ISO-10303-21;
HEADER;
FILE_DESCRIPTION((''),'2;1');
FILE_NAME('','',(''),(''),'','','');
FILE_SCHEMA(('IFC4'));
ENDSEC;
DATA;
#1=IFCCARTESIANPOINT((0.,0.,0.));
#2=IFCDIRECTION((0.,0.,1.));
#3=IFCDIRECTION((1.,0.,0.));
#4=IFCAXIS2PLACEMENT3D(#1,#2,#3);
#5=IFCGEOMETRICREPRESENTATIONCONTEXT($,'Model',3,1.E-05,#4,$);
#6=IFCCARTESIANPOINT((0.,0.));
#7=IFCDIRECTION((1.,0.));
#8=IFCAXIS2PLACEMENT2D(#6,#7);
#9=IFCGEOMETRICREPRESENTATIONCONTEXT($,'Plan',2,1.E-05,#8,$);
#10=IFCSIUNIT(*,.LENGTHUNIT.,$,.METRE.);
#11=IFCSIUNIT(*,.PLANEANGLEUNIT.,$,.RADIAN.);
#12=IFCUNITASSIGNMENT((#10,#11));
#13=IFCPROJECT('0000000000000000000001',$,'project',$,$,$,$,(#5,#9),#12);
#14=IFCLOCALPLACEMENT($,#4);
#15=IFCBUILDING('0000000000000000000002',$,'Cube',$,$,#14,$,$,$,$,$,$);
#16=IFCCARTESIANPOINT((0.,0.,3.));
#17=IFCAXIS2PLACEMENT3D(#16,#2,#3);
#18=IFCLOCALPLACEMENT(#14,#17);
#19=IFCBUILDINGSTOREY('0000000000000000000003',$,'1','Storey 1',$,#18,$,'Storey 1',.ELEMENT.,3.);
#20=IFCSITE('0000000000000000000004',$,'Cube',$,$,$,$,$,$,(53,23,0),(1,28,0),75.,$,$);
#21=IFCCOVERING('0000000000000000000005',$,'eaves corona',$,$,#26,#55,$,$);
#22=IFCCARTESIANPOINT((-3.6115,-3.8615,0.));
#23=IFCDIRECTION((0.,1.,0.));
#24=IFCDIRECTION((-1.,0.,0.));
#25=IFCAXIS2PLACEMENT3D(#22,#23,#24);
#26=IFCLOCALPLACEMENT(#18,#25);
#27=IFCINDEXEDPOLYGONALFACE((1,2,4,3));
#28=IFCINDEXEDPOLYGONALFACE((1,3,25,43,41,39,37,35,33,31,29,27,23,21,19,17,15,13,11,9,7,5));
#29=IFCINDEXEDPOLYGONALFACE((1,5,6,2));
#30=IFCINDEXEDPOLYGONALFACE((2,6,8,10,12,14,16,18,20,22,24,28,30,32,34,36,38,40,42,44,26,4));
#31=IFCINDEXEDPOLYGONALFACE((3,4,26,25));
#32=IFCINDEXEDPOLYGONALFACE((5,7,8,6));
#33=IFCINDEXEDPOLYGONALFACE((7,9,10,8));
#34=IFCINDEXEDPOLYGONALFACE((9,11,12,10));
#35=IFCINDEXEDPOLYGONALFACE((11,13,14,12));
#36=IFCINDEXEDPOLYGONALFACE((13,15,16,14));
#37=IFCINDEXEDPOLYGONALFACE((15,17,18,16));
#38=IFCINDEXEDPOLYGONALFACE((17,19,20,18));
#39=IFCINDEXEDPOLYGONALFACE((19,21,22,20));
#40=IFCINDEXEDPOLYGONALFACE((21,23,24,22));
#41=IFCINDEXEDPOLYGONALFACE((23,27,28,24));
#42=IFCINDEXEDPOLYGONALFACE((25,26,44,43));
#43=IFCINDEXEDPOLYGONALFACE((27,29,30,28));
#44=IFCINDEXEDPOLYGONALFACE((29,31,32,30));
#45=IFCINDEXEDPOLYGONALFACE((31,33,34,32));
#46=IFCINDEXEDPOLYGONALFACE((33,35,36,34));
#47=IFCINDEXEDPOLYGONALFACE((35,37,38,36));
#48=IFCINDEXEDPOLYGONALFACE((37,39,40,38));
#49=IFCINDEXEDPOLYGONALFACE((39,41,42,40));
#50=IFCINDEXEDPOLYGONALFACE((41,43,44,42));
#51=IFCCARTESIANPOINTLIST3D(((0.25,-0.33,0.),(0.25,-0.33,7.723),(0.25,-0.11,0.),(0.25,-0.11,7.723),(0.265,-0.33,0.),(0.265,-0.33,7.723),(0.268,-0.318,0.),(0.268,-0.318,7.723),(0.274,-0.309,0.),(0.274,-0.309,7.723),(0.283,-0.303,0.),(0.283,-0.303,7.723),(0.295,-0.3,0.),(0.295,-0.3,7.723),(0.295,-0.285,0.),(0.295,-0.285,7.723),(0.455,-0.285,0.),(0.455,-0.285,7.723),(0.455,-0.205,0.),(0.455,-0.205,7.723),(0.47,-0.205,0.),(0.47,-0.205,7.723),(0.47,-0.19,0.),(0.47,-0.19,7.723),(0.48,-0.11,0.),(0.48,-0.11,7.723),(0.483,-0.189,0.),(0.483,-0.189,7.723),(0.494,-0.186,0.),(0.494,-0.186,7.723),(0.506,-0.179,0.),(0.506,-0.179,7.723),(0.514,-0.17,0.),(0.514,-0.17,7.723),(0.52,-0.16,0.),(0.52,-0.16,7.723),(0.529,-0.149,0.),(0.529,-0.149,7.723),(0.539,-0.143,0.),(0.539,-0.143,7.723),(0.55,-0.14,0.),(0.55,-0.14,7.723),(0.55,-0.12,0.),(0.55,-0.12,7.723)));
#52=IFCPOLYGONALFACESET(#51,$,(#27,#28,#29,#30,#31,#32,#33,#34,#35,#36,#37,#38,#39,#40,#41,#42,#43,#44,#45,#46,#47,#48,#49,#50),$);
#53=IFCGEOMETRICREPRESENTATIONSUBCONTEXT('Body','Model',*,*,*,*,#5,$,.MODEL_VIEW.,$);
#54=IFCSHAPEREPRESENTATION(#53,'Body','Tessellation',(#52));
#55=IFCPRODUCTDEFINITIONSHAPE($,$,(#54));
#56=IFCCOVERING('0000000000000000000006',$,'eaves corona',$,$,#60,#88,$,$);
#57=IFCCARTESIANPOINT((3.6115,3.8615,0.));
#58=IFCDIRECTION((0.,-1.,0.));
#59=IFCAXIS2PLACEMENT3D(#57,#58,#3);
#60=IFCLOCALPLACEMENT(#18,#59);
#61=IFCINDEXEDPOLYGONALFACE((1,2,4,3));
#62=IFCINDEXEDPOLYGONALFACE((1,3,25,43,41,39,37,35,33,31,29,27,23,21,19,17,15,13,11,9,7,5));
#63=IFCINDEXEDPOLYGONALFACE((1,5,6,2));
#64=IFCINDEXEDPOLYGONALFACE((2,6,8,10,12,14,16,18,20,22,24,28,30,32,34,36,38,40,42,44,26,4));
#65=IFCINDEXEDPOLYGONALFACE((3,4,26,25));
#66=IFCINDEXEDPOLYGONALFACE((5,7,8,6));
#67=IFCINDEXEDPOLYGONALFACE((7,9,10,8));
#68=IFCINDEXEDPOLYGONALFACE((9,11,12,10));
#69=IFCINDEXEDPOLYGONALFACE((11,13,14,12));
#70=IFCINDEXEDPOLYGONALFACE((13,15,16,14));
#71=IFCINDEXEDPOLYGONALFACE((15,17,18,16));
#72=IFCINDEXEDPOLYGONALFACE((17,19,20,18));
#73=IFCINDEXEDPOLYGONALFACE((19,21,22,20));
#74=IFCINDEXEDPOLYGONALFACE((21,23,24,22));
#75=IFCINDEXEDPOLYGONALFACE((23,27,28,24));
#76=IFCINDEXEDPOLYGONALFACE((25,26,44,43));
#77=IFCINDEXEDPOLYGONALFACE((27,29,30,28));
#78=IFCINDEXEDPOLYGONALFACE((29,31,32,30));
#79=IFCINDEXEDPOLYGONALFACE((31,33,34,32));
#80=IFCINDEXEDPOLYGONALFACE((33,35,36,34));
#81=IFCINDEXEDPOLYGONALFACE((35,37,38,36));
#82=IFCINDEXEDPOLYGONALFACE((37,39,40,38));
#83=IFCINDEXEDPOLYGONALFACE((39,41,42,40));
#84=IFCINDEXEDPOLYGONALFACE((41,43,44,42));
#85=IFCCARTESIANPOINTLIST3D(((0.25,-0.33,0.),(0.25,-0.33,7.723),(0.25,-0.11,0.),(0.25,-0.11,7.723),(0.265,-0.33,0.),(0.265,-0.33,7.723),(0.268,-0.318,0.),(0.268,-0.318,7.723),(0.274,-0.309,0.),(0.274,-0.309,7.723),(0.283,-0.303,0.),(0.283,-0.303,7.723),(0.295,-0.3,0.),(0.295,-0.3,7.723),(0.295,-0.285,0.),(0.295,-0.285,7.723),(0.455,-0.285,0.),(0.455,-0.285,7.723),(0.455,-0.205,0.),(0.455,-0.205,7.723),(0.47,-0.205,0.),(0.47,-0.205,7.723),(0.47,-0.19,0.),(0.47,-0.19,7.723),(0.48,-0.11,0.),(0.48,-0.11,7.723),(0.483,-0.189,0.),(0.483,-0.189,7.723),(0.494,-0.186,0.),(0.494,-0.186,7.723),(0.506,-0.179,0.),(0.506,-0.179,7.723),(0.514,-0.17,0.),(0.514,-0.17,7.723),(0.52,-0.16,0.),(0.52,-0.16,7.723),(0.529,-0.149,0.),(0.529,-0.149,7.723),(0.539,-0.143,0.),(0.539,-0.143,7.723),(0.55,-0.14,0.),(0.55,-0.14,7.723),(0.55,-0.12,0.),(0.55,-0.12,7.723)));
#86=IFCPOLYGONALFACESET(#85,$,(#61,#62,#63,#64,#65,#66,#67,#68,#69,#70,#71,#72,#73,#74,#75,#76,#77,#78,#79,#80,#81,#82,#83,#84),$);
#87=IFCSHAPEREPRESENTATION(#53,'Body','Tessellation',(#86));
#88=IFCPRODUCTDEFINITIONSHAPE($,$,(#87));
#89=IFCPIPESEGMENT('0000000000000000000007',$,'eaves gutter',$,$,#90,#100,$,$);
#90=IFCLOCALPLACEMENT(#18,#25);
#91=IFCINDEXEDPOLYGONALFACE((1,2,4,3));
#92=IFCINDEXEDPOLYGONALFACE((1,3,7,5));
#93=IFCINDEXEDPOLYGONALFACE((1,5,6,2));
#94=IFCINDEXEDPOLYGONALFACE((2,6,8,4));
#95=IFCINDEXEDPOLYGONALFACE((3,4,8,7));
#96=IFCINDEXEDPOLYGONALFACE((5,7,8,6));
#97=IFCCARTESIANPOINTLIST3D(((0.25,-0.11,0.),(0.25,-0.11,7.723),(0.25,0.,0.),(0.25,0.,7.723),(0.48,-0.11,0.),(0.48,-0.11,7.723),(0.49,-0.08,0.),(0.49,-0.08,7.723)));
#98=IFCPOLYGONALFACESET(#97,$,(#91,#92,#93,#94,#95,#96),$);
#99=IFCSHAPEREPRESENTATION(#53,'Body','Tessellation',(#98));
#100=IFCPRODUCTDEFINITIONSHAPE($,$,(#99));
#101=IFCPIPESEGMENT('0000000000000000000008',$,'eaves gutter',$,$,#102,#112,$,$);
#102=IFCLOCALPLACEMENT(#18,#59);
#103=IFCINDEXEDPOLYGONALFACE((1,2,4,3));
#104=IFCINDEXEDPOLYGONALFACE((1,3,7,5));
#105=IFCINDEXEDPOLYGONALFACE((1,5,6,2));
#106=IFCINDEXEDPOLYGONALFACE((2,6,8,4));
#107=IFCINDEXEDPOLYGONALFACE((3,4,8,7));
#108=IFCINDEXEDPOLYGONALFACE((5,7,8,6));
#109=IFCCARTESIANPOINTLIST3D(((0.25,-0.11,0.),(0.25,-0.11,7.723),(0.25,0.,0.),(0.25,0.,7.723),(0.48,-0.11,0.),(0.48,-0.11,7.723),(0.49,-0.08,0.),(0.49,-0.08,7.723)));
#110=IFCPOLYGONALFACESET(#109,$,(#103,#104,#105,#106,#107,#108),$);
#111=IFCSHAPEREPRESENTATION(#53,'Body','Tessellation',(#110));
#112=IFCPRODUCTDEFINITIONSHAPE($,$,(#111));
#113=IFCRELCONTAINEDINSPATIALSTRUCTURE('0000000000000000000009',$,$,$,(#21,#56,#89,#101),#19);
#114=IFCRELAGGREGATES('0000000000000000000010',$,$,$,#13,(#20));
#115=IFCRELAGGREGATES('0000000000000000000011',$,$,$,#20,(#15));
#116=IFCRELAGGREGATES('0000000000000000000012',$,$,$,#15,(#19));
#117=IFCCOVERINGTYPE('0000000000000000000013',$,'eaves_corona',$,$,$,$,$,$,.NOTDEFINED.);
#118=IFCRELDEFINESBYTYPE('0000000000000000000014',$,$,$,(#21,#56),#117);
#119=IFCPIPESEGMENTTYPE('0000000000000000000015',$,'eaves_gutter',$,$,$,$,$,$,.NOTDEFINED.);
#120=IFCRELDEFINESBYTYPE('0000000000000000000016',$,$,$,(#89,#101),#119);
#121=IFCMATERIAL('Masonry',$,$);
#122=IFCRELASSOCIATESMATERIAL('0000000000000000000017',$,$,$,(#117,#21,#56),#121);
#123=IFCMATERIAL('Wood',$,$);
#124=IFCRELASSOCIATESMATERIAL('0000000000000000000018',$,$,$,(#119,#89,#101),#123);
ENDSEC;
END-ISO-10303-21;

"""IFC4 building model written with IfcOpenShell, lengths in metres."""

from ifc_helpers import new_model, si_unit, frame, origin_with_axes, origin_2d_with_axis, place, context, subcontext, project, spatial, polyline, outline, extrude, material, material_profile, profile_set, profile_usage, type_object, element, save


model = new_model("IFC4")

# Units and contexts
model_context = context("Model", 3, precision=1e-05, world=origin_with_axes())
plan_context = context("Plan", 2, precision=1e-05, world=origin_2d_with_axis())
body_context = subcontext(model_context, "Body", "Model", "MODEL_VIEW")
ifc_project = project(units=[si_unit("LENGTHUNIT", "METRE"), si_unit("PLANEANGLEUNIT", "RADIAN")], contexts=[model_context, plan_context])

# Site, building, storey
site = spatial("IfcSite", under=ifc_project, Name="Cube", RefLatitude=(53, 23, 0), RefLongitude=(1, 28, 0), RefElevation=75.0)
building_placement = place(None, origin_with_axes())
building = spatial("IfcBuilding", under=site, at=building_placement, Name="Cube")
storey_placement = place(building_placement, frame((0.0, 0.0, 3.0), z_axis=(0.0, 0.0, 1.0), x_axis=(1.0, 0.0, 0.0)))
storey = spatial("IfcBuildingStorey", under=building, at=storey_placement, Name="1", Description="Storey 1", LongName="Storey 1", CompositionType="ELEMENT", Elevation=3.0)

# Coverings
ifc_material_1 = material(Name="Masonry")
ifc_material_profile_1 = material_profile(ifc_material_1, outline(polyline([(0.25, -0.11), (0.25, -0.33), (0.265, -0.33), (0.268, -0.318), (0.274, -0.309), (0.283, -0.303), (0.295, -0.3), (0.295, -0.285), (0.455, -0.285), (0.455, -0.205), (0.47, -0.205), (0.47, -0.19), (0.483, -0.189), (0.494, -0.186), (0.506, -0.179), (0.514, -0.17), (0.52, -0.16), (0.529, -0.149), (0.539, -0.143), (0.55, -0.14), (0.55, -0.12), (0.48, -0.11), (0.25, -0.11)])))
ifc_profile_set_1 = profile_set([ifc_material_profile_1])
ifc_profile_usage_1 = profile_usage(ifc_profile_set_1)
covering_type_1 = type_object("IfcCoveringType", Name="eaves_corona", PredefinedType="NOTDEFINED", material=ifc_profile_set_1)
covering_1_placement = place(storey_placement, frame((-3.6115, -3.8615, 0.0), z_axis=(0.0, 1.0, 0.0), x_axis=(-1.0, 0.0, 0.0)))
element("IfcCovering", 1, at=covering_1_placement, inside=storey, type_object=covering_type_1, material=ifc_profile_usage_1, Name="eaves corona", context=body_context, shape_type="SweptSolid", body=[
    extrude(outline(polyline([(0.25, -0.11), (0.25, -0.33), (0.265, -0.33), (0.268, -0.318), (0.274, -0.309), (0.283, -0.303), (0.295, -0.3), (0.295, -0.285), (0.455, -0.285), (0.455, -0.205), (0.47, -0.205), (0.47, -0.19), (0.483, -0.189), (0.494, -0.186), (0.506, -0.179), (0.514, -0.17), (0.52, -0.16), (0.529, -0.149), (0.539, -0.143), (0.55, -0.14), (0.55, -0.12), (0.48, -0.11), (0.25, -0.11)])), origin_with_axes(), (0.0, 0.0, 1.0), 7.723),
])
ifc_profile_usage_2 = profile_usage(ifc_profile_set_1)
covering_2_placement = place(storey_placement, frame((3.6115, 3.8615, 0.0), z_axis=(0.0, -1.0, 0.0), x_axis=(1.0, 0.0, 0.0)))
element("IfcCovering", 2, at=covering_2_placement, inside=storey, type_object=covering_type_1, material=ifc_profile_usage_2, Name="eaves corona", context=body_context, shape_type="SweptSolid", body=[
    extrude(outline(polyline([(0.25, -0.11), (0.25, -0.33), (0.265, -0.33), (0.268, -0.318), (0.274, -0.309), (0.283, -0.303), (0.295, -0.3), (0.295, -0.285), (0.455, -0.285), (0.455, -0.205), (0.47, -0.205), (0.47, -0.19), (0.483, -0.189), (0.494, -0.186), (0.506, -0.179), (0.514, -0.17), (0.52, -0.16), (0.529, -0.149), (0.539, -0.143), (0.55, -0.14), (0.55, -0.12), (0.48, -0.11), (0.25, -0.11)])), origin_with_axes(), (0.0, 0.0, 1.0), 7.723),
])

# Pipe segments
ifc_material_2 = material(Name="Wood")
ifc_material_profile_2 = material_profile(ifc_material_2, outline(polyline([(0.25, -0.11), (0.48, -0.11), (0.49, -0.08), (0.25, 0.0), (0.25, -0.11)])))
ifc_profile_set_2 = profile_set([ifc_material_profile_2])
ifc_profile_usage_3 = profile_usage(ifc_profile_set_2)
pipe_segment_type = type_object("IfcPipeSegmentType", Name="eaves_gutter", PredefinedType="NOTDEFINED", material=ifc_profile_set_2)
pipe_segment_1_placement = place(storey_placement, frame((-3.6115, -3.8615, 0.0), z_axis=(0.0, 1.0, 0.0), x_axis=(-1.0, 0.0, 0.0)))
element("IfcPipeSegment", 3, at=pipe_segment_1_placement, inside=storey, type_object=pipe_segment_type, material=ifc_profile_usage_3, Name="eaves gutter", context=body_context, shape_type="SweptSolid", body=[
    extrude(outline(polyline([(0.25, -0.11), (0.48, -0.11), (0.49, -0.08), (0.25, 0.0), (0.25, -0.11)])), origin_with_axes(), (0.0, 0.0, 1.0), 7.723),
])
ifc_profile_usage_4 = profile_usage(ifc_profile_set_2)
pipe_segment_2_placement = place(storey_placement, frame((3.6115, 3.8615, 0.0), z_axis=(0.0, -1.0, 0.0), x_axis=(1.0, 0.0, 0.0)))
element("IfcPipeSegment", 4, at=pipe_segment_2_placement, inside=storey, type_object=pipe_segment_type, material=ifc_profile_usage_4, Name="eaves gutter", context=body_context, shape_type="SweptSolid", body=[
    extrude(outline(polyline([(0.25, -0.11), (0.48, -0.11), (0.49, -0.08), (0.25, 0.0), (0.25, -0.11)])), origin_with_axes(), (0.0, 0.0, 1.0), 7.723),
])

save(model, "model.ifc")
